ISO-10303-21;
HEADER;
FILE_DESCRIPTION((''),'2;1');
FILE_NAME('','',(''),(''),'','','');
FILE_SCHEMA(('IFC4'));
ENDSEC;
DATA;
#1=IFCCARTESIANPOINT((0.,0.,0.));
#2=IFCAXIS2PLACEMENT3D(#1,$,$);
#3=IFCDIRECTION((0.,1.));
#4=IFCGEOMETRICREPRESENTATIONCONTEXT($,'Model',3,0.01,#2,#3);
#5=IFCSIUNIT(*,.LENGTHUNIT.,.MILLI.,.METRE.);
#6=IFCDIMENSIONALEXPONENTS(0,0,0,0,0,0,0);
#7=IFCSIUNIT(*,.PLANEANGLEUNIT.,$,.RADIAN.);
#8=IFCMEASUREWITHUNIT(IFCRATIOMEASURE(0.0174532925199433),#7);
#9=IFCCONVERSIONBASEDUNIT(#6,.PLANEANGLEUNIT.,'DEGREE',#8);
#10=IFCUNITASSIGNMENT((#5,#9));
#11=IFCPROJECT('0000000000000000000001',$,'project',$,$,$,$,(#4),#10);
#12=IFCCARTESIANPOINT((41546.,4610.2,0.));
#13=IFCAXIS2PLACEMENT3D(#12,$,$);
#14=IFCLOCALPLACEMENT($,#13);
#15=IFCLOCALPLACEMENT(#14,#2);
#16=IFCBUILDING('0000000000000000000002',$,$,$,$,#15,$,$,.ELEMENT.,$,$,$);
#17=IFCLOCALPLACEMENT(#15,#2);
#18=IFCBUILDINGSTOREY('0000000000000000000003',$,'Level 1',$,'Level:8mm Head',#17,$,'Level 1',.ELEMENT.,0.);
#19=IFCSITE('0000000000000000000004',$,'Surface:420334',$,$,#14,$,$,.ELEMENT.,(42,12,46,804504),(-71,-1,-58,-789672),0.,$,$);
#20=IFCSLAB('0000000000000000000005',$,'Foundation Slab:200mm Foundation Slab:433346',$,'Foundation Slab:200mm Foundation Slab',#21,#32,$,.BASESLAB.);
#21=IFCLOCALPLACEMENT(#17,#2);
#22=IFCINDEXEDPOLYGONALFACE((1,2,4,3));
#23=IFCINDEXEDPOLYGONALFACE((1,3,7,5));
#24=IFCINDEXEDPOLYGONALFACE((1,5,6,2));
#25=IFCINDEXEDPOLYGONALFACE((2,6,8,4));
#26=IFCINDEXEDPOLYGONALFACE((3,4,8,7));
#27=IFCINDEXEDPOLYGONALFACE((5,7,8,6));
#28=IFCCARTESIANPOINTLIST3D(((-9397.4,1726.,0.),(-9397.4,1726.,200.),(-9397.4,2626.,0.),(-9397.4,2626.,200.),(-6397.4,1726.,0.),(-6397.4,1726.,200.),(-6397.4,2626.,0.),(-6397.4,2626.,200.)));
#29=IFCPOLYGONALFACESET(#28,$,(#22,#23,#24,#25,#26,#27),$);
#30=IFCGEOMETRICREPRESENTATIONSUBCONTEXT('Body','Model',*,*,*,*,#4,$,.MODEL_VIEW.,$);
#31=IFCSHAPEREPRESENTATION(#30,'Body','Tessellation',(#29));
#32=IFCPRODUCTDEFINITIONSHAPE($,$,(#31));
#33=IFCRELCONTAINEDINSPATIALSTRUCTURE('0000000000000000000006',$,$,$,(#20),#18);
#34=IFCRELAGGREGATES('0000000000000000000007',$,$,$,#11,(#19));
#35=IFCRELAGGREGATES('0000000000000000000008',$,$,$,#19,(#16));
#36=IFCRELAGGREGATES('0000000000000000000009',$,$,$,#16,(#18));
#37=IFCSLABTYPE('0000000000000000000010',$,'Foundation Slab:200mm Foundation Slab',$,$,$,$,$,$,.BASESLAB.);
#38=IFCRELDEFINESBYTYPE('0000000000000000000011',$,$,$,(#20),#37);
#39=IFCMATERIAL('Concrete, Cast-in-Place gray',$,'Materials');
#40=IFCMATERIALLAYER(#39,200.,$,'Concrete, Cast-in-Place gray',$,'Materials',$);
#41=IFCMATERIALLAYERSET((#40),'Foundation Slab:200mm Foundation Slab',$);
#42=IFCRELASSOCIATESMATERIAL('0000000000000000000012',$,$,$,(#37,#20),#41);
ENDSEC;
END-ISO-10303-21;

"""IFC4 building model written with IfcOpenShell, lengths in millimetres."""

from ifc_helpers import new_model, entity, si_unit, converted_unit, direction, frame, frame_2d, origin, place, context, subcontext, project, spatial, rectangle, extrude, material, layer, layer_set, layer_usage, type_object, element, save


model = new_model("IFC4")

# Units and contexts
model_context = context("Model", 3, precision=0.01, world=origin(), true_north=direction((0.0, 1.0)))
body_context = subcontext(model_context, "Body", "Model", "MODEL_VIEW")
ifc_project = project(units=[si_unit("LENGTHUNIT", "METRE", prefix="MILLI"), converted_unit("PLANEANGLEUNIT", "DEGREE", entity("IfcRatioMeasure", 0.0174532925199433), si_unit("PLANEANGLEUNIT", "RADIAN"), dimensions=[0, 0, 0, 0, 0, 0, 0])], contexts=[model_context])

# Site, building, storey
site_placement = place(None, frame((41546.0, 4610.2, 0.0)))
site = spatial("IfcSite", under=ifc_project, at=site_placement, Name="Surface:420334", CompositionType="ELEMENT", RefLatitude=(42, 12, 46, 804504), RefLongitude=(-71, -1, -58, -789672), RefElevation=0.0)
building_placement = place(site_placement, origin())
building = spatial("IfcBuilding", under=site, at=building_placement, CompositionType="ELEMENT")
storey_placement = place(building_placement, origin())
storey = spatial("IfcBuildingStorey", under=building, at=storey_placement, Name="Level 1", ObjectType="Level:8mm Head", LongName="Level 1", CompositionType="ELEMENT", Elevation=0.0)

# Slab
ifc_material = material(Name="Concrete, Cast-in-Place gray", Category="Materials")
ifc_layer = layer(ifc_material, 200.0, Name="Concrete, Cast-in-Place gray", Category="Materials")
ifc_layer_set = layer_set([ifc_layer], Name="Foundation Slab:200mm Foundation Slab")
ifc_layer_usage_1 = layer_usage(ifc_layer_set, "AXIS3", "POSITIVE", 0.0)
slab_type_1 = type_object("IfcSlabType", Name="Foundation Slab:200mm Foundation Slab", PredefinedType="BASESLAB", material=ifc_layer_set)
slab_1_placement = place(storey_placement, origin())
element("IfcSlab", 1, at=slab_1_placement, inside=storey, type_object=slab_type_1, material=ifc_layer_usage_1, Name="Foundation Slab:200mm Foundation Slab:433346", ObjectType="Foundation Slab:200mm Foundation Slab", PredefinedType="BASESLAB", context=body_context, shape_type="SweptSolid", body=[
    extrude(rectangle(XDim=900.0, YDim=3000.0, at=frame_2d((0.0, 0.0), x_axis=(1.0, 0.0))), frame((-7897.4, 2176.0, 200.0), z_axis=(0.0, 0.0, -1.0), x_axis=(0.0, 1.0, 0.0)), (0.0, 0.0, 1.0), 200.0),
])

save(model, "model.ifc")
